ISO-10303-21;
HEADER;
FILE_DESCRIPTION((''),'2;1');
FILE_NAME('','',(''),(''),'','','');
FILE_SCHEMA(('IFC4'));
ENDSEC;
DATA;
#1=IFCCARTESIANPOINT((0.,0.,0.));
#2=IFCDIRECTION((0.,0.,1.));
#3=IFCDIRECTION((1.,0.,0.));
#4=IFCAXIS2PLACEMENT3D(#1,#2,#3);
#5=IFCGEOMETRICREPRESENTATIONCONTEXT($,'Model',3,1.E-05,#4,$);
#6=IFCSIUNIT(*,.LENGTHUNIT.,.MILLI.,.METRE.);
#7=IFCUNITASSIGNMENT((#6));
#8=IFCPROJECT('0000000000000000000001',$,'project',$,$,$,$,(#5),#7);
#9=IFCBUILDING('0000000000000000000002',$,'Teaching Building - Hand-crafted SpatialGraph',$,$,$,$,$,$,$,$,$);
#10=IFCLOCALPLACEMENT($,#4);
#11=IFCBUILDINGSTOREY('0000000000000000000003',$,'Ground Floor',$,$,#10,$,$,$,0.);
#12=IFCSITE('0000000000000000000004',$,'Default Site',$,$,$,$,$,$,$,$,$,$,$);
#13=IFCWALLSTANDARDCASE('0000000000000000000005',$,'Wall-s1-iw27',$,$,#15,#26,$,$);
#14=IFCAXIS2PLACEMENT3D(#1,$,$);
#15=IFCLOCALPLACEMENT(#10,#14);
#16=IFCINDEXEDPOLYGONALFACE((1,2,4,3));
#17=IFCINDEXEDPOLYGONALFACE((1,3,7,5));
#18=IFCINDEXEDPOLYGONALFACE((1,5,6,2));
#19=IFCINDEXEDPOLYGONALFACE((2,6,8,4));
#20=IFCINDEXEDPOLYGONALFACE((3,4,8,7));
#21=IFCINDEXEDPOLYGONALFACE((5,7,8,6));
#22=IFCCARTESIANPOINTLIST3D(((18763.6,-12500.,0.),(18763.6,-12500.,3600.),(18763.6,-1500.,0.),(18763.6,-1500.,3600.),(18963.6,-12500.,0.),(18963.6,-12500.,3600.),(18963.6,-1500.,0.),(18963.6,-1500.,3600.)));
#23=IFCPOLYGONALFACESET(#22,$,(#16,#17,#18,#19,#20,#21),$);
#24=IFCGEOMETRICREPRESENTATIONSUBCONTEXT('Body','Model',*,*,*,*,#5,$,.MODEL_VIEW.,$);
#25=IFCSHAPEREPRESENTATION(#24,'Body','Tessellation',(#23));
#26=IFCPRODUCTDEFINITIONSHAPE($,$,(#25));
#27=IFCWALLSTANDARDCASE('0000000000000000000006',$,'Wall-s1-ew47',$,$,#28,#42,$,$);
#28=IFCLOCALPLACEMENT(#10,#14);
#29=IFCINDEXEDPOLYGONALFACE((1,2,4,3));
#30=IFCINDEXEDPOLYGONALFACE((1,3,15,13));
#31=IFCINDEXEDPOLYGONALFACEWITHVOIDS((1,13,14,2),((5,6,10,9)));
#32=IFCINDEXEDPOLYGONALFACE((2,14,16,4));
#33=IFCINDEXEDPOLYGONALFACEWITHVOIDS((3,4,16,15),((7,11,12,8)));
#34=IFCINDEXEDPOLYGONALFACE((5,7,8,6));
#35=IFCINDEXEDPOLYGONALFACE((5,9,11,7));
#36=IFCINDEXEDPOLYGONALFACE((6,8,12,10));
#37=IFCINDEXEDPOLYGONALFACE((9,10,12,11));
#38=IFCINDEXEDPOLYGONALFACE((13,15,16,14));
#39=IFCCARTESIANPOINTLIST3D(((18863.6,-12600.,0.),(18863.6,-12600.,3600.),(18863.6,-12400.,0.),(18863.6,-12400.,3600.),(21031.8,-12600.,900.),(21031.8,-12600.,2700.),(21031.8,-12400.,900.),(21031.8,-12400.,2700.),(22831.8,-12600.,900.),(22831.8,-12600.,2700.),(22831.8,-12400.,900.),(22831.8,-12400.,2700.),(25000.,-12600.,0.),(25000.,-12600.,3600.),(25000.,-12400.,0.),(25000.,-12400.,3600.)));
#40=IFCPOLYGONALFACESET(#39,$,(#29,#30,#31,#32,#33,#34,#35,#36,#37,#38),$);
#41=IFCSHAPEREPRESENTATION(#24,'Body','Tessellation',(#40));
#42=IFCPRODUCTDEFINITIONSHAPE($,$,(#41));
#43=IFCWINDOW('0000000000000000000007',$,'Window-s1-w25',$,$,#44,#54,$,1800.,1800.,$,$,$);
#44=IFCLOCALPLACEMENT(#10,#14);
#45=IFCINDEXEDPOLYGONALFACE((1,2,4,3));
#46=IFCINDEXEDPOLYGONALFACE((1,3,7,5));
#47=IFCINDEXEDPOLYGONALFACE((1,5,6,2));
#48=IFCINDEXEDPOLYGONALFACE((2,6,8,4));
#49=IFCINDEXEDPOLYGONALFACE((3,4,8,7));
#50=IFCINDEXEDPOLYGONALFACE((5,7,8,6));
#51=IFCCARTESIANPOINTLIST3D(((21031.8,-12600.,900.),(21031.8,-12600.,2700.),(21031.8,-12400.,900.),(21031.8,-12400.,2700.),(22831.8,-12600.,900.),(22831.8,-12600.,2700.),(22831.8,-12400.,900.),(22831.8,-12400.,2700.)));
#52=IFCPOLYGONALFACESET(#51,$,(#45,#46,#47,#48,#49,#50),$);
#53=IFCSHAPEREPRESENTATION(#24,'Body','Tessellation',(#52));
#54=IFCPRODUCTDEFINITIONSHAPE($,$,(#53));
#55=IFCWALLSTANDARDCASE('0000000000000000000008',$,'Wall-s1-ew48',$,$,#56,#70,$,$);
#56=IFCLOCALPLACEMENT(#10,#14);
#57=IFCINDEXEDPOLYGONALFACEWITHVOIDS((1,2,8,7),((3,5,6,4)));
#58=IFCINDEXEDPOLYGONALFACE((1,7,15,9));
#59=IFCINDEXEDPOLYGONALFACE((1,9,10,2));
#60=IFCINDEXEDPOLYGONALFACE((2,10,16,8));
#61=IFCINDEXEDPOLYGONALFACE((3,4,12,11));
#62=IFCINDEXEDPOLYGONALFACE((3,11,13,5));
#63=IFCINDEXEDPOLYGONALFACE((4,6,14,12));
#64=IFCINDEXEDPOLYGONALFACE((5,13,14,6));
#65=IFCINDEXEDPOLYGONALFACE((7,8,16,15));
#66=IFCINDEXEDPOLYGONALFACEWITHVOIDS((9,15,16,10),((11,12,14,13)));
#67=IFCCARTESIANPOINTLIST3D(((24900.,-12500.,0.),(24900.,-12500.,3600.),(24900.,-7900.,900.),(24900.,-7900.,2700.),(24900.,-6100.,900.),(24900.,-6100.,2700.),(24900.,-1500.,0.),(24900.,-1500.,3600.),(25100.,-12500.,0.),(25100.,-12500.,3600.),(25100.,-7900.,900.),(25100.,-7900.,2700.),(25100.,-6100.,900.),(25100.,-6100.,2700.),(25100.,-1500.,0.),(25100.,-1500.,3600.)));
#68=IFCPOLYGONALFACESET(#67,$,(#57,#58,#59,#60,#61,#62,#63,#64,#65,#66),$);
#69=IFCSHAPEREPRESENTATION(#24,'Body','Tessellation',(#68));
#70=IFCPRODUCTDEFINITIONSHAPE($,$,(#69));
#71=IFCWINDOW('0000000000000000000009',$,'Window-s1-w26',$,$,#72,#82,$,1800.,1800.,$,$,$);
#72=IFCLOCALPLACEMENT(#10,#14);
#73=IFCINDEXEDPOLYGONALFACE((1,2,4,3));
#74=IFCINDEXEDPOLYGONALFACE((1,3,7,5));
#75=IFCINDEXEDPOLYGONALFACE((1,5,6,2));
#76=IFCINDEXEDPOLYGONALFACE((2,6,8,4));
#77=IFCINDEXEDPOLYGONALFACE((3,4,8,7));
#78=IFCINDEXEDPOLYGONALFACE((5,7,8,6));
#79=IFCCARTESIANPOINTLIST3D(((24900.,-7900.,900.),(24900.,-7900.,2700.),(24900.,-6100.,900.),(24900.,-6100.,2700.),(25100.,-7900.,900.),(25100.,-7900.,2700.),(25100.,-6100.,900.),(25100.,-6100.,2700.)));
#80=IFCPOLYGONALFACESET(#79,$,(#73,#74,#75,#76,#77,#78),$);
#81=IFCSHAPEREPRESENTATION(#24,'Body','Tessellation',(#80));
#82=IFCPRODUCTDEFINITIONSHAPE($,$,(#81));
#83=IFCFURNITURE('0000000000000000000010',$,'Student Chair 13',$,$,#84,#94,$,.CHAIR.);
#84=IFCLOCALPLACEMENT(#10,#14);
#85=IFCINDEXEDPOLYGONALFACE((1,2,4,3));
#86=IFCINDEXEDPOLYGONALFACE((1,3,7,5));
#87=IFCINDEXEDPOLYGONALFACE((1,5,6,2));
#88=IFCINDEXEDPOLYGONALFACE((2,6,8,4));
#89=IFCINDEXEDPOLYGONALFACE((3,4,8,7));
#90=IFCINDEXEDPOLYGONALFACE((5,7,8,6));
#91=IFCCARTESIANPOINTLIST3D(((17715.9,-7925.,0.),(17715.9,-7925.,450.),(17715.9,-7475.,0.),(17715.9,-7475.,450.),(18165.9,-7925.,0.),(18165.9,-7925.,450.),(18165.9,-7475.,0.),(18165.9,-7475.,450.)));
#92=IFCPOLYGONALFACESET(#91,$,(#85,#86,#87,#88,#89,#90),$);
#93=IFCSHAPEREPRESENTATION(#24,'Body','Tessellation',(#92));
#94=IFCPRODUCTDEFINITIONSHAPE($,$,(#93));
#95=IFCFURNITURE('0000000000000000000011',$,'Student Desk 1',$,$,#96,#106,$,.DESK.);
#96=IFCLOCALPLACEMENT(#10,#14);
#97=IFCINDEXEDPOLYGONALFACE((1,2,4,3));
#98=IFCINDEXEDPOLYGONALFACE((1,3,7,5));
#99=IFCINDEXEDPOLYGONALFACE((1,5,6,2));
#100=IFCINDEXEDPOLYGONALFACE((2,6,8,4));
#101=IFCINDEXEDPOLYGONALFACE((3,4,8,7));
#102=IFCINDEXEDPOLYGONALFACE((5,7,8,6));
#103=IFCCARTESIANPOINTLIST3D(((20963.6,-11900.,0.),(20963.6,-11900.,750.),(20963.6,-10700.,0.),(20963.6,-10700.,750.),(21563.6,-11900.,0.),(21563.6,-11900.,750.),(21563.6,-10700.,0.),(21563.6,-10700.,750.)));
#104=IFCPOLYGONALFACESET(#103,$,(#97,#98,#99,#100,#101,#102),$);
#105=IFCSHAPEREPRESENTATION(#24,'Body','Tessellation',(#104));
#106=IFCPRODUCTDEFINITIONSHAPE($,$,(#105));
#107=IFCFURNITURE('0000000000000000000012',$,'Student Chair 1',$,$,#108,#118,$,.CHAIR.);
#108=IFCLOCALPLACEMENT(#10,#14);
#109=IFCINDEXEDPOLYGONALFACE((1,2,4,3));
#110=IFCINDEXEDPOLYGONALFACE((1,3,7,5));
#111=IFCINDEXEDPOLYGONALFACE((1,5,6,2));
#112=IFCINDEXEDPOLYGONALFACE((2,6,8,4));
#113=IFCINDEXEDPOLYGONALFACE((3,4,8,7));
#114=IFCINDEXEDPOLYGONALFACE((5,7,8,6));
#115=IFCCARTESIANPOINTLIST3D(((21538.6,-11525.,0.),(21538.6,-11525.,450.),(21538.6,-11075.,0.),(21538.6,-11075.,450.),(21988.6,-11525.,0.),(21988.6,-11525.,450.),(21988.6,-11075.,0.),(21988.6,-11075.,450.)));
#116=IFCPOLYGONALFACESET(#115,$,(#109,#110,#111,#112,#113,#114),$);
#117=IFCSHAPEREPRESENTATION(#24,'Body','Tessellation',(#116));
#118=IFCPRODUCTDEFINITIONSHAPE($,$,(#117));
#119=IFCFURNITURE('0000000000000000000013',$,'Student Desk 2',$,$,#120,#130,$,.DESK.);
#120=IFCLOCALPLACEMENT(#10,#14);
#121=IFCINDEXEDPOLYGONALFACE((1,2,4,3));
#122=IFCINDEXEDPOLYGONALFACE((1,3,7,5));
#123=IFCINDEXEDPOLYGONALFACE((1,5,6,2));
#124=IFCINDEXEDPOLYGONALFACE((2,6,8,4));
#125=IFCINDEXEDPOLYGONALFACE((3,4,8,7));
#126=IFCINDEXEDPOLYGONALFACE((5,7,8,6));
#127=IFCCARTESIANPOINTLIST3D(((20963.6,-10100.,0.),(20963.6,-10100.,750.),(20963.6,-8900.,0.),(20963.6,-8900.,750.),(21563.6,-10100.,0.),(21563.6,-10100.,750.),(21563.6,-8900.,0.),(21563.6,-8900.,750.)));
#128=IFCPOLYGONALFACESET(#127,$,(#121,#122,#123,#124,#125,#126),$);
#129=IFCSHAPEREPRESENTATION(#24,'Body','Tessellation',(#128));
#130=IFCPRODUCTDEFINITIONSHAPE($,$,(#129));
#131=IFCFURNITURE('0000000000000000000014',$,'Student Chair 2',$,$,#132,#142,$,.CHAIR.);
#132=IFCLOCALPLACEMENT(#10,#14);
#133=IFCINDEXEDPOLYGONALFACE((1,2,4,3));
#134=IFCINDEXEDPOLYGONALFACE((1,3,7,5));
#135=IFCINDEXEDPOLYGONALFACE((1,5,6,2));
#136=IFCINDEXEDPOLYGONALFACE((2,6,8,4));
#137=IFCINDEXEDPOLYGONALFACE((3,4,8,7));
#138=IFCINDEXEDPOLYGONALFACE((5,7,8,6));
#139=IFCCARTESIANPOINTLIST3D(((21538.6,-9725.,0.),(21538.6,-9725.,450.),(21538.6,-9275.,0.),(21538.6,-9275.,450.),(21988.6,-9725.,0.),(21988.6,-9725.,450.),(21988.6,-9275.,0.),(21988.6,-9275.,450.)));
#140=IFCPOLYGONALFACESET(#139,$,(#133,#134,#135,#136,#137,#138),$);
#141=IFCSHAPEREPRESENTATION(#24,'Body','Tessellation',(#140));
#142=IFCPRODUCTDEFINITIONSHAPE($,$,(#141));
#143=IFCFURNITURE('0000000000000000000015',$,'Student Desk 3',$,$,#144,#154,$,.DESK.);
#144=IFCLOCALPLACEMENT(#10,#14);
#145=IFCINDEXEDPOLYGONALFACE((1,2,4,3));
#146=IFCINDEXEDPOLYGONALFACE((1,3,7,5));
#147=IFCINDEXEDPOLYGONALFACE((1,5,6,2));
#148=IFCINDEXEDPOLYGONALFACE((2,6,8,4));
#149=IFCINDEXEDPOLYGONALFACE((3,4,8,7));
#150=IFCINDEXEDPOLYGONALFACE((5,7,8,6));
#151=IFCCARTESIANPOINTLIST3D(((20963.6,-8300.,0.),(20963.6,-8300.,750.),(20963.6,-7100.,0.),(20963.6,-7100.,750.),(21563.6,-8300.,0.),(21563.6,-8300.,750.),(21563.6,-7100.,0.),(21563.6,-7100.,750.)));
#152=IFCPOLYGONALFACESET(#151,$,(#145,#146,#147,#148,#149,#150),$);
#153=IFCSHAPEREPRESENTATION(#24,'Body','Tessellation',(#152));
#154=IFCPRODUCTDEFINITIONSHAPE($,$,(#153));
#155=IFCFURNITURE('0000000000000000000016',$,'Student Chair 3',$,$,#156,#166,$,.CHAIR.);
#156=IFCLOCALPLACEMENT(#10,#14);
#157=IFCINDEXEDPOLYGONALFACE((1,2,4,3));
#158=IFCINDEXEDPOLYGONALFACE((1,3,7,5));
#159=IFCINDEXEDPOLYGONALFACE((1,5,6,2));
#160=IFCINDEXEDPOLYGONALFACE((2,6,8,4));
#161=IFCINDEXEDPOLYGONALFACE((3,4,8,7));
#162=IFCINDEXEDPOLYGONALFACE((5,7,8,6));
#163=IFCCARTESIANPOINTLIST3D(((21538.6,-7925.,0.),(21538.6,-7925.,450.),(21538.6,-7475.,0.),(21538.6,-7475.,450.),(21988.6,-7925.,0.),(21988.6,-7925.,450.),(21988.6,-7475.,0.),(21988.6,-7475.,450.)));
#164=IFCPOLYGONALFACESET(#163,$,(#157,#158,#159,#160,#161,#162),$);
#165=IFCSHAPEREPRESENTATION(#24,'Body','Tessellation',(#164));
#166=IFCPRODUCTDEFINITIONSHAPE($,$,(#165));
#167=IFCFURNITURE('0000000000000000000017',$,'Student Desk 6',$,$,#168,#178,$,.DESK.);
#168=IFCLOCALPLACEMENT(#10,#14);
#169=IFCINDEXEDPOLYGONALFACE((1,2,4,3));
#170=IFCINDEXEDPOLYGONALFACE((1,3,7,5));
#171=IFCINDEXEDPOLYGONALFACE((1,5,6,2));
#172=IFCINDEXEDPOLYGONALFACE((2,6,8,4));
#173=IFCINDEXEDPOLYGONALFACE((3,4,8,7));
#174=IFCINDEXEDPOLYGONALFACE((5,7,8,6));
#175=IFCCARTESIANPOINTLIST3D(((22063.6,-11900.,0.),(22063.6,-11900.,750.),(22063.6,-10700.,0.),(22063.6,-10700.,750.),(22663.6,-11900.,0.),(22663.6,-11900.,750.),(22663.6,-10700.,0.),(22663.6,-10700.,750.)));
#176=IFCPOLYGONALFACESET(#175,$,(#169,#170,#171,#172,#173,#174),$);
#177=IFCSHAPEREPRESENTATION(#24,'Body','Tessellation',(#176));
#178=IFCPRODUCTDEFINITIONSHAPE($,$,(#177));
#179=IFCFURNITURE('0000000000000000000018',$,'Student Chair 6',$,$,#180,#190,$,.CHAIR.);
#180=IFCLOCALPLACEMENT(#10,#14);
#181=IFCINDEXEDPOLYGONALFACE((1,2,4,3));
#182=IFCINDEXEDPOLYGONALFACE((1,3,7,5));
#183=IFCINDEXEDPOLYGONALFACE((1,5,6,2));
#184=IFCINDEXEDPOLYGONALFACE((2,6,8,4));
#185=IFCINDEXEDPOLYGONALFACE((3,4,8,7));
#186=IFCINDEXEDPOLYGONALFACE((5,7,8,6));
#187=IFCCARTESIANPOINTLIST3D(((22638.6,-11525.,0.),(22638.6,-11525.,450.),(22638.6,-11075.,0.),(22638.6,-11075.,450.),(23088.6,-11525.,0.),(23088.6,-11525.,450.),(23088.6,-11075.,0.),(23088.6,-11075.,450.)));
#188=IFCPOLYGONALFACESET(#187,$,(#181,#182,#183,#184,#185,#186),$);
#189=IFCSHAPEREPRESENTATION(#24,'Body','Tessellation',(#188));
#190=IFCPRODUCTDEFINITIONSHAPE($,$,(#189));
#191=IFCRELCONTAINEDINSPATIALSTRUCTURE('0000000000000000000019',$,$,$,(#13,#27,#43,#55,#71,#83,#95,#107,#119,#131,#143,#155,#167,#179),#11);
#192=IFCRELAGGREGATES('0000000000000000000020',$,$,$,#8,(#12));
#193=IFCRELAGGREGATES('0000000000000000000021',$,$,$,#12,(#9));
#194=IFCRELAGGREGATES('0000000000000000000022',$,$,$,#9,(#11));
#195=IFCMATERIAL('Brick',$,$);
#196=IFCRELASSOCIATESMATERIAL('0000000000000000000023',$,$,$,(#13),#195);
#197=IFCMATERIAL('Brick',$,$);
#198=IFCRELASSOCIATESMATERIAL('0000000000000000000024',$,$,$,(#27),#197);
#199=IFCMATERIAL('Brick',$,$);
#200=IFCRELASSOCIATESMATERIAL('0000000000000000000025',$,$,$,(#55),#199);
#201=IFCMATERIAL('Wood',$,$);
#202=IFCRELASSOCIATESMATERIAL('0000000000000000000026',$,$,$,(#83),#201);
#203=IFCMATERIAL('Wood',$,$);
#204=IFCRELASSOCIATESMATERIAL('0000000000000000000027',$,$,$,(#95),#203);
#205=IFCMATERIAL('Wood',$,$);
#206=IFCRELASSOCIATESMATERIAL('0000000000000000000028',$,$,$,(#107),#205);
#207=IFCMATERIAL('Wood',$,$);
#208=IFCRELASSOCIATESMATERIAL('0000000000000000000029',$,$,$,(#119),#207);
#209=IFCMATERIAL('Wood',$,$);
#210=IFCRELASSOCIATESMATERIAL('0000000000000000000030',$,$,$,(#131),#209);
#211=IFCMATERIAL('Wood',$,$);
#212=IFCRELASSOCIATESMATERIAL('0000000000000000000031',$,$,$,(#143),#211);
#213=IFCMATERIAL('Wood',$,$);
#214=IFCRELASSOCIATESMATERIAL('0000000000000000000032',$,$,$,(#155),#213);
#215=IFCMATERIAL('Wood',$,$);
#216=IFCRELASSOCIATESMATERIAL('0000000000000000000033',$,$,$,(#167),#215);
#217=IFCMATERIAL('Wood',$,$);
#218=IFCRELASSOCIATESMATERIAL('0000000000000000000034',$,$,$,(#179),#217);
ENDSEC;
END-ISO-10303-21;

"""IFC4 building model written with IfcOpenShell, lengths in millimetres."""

from ifc_helpers import new_model, si_unit, frame, frame_2d, origin_with_axes, origin_2d, place, context, subcontext, project, spatial, rectangle, extrude, material, element, fill, save


model = new_model("IFC4")

# Units and contexts
model_context = context("Model", 3, precision=1e-05, world=origin_with_axes())
body_context = subcontext(model_context, "Body", "Model", "MODEL_VIEW")
ifc_project = project(units=[si_unit("LENGTHUNIT", "METRE", prefix="MILLI")], contexts=[model_context])

# Site, building, storey
site = spatial("IfcSite", under=ifc_project, Name="Default Site")
building = spatial("IfcBuilding", under=site, Name="Teaching Building - Hand-crafted SpatialGraph")
storey_placement = place(None, origin_with_axes())
storey = spatial("IfcBuildingStorey", under=building, at=storey_placement, Name="Ground Floor", Elevation=0.0)

# Wall
ifc_material_1 = material(Name="Brick")
wall_1_placement = place(storey_placement, frame((18863.6, -12500.0, 0.0), z_axis=(0.0, 0.0, 1.0), x_axis=(0.0, 1.0, 0.0)))
element("IfcWallStandardCase", 1, at=wall_1_placement, inside=storey, material=ifc_material_1, Name="Wall-s1-iw27", context=body_context, shape_type="SweptSolid", body=[
    extrude(rectangle(XDim=11000.0, YDim=200.0, at=frame_2d((5500.0, 0.0))), origin_with_axes(), (0.0, 0.0, 1.0), 3600.0),
])

# Walls, openings, windows
ifc_material_2 = material(Name="Brick")
wall_2_placement = place(storey_placement, frame((18863.6, -12500.0, 0.0), z_axis=(0.0, 0.0, 1.0), x_axis=(1.0, 0.0, 0.0)))
wall_2 = element("IfcWallStandardCase", 2, at=wall_2_placement, inside=storey, material=ifc_material_2, Name="Wall-s1-ew47", context=body_context, shape_type="SweptSolid", body=[
    extrude(rectangle(XDim=6136.4, YDim=200.0, at=frame_2d((3068.2, 0.0))), origin_with_axes(), (0.0, 0.0, 1.0), 3600.0),
])
opening_1_placement = place(wall_2_placement, frame((2168.2, 0.0, 900.0), z_axis=(0.0, 0.0, 1.0), x_axis=(1.0, 0.0, 0.0)))
opening_1 = element("IfcOpeningElement", 3, at=opening_1_placement, cuts=wall_2, context=body_context, shape_type="SweptSolid", body=[
    extrude(rectangle(XDim=1800.0, YDim=400.0, at=frame_2d((900.0, 0.0))), origin_with_axes(), (0.0, 0.0, 1.0), 1800.0),
])
window_1_placement = place(storey_placement, frame((21031.8, -12500.0, 900.0), z_axis=(0.0, 0.0, 1.0), x_axis=(1.0, 0.0, 0.0)))
window_1 = element("IfcWindow", 4, at=window_1_placement, inside=storey, Name="Window-s1-w25", OverallHeight=1800.0, OverallWidth=1800.0, context=body_context, shape_type="SweptSolid", body=[
    extrude(rectangle(XDim=1800.0, YDim=200.0, at=frame_2d((900.0, 0.0))), origin_with_axes(), (0.0, 0.0, 1.0), 1800.0),
])
fill(opening_1, window_1)
ifc_material_3 = material(Name="Brick")
wall_3_placement = place(storey_placement, frame((25000.0, -12500.0, 0.0), z_axis=(0.0, 0.0, 1.0), x_axis=(0.0, 1.0, 0.0)))
wall_3 = element("IfcWallStandardCase", 5, at=wall_3_placement, inside=storey, material=ifc_material_3, Name="Wall-s1-ew48", context=body_context, shape_type="SweptSolid", body=[
    extrude(rectangle(XDim=11000.0, YDim=200.0, at=frame_2d((5500.0, 0.0))), origin_with_axes(), (0.0, 0.0, 1.0), 3600.0),
])
opening_2_placement = place(wall_3_placement, frame((4600.0, 0.0, 900.0), z_axis=(0.0, 0.0, 1.0), x_axis=(1.0, 0.0, 0.0)))
opening_2 = element("IfcOpeningElement", 6, at=opening_2_placement, cuts=wall_3, context=body_context, shape_type="SweptSolid", body=[
    extrude(rectangle(XDim=1800.0, YDim=400.0, at=frame_2d((900.0, 0.0))), origin_with_axes(), (0.0, 0.0, 1.0), 1800.0),
])
window_2_placement = place(storey_placement, frame((25000.0, -7900.0, 900.0), z_axis=(0.0, 0.0, 1.0), x_axis=(0.0, 1.0, 0.0)))
window_2 = element("IfcWindow", 7, at=window_2_placement, inside=storey, Name="Window-s1-w26", OverallHeight=1800.0, OverallWidth=1800.0, context=body_context, shape_type="SweptSolid", body=[
    extrude(rectangle(XDim=1800.0, YDim=200.0, at=frame_2d((900.0, 0.0))), origin_with_axes(), (0.0, 0.0, 1.0), 1800.0),
])
fill(opening_2, window_2)

# Furniture
ifc_material_4 = material(Name="Wood")
furniture_1_placement = place(storey_placement, frame((17940.9, -7700.0, 0.0), z_axis=(0.0, 0.0, 1.0), x_axis=(1.0, 0.0, 0.0)))
element("IfcFurniture", 8, at=furniture_1_placement, inside=storey, material=ifc_material_4, Name="Student Chair 13", PredefinedType="CHAIR", context=body_context, shape_type="SweptSolid", body=[
    extrude(rectangle(XDim=450.0, YDim=450.0, at=origin_2d()), origin_with_axes(), (0.0, 0.0, 1.0), 450.0),
])
ifc_material_5 = material(Name="Wood")
furniture_2_placement = place(storey_placement, frame((21263.6, -11300.0, 0.0), z_axis=(0.0, 0.0, 1.0), x_axis=(0.0, 1.0, 0.0)))
element("IfcFurniture", 9, at=furniture_2_placement, inside=storey, material=ifc_material_5, Name="Student Desk 1", PredefinedType="DESK", context=body_context, shape_type="SweptSolid", body=[
    extrude(rectangle(XDim=1200.0, YDim=600.0, at=origin_2d()), origin_with_axes(), (0.0, 0.0, 1.0), 750.0),
])
ifc_material_6 = material(Name="Wood")
furniture_3_placement = place(storey_placement, frame((21763.6, -11300.0, 0.0), z_axis=(0.0, 0.0, 1.0), x_axis=(1.0, 0.0, 0.0)))
element("IfcFurniture", 10, at=furniture_3_placement, inside=storey, material=ifc_material_6, Name="Student Chair 1", PredefinedType="CHAIR", context=body_context, shape_type="SweptSolid", body=[
    extrude(rectangle(XDim=450.0, YDim=450.0, at=origin_2d()), origin_with_axes(), (0.0, 0.0, 1.0), 450.0),
])
ifc_material_7 = material(Name="Wood")
furniture_4_placement = place(storey_placement, frame((21263.6, -9500.0, 0.0), z_axis=(0.0, 0.0, 1.0), x_axis=(0.0, 1.0, 0.0)))
element("IfcFurniture", 11, at=furniture_4_placement, inside=storey, material=ifc_material_7, Name="Student Desk 2", PredefinedType="DESK", context=body_context, shape_type="SweptSolid", body=[
    extrude(rectangle(XDim=1200.0, YDim=600.0, at=origin_2d()), origin_with_axes(), (0.0, 0.0, 1.0), 750.0),
])
ifc_material_8 = material(Name="Wood")
furniture_5_placement = place(storey_placement, frame((21763.6, -9500.0, 0.0), z_axis=(0.0, 0.0, 1.0), x_axis=(1.0, 0.0, 0.0)))
element("IfcFurniture", 12, at=furniture_5_placement, inside=storey, material=ifc_material_8, Name="Student Chair 2", PredefinedType="CHAIR", context=body_context, shape_type="SweptSolid", body=[
    extrude(rectangle(XDim=450.0, YDim=450.0, at=origin_2d()), origin_with_axes(), (0.0, 0.0, 1.0), 450.0),
])
ifc_material_9 = material(Name="Wood")
furniture_6_placement = place(storey_placement, frame((21263.6, -7700.0, 0.0), z_axis=(0.0, 0.0, 1.0), x_axis=(0.0, 1.0, 0.0)))
element("IfcFurniture", 13, at=furniture_6_placement, inside=storey, material=ifc_material_9, Name="Student Desk 3", PredefinedType="DESK", context=body_context, shape_type="SweptSolid", body=[
    extrude(rectangle(XDim=1200.0, YDim=600.0, at=origin_2d()), origin_with_axes(), (0.0, 0.0, 1.0), 750.0),
])
ifc_material_10 = material(Name="Wood")
furniture_7_placement = place(storey_placement, frame((21763.6, -7700.0, 0.0), z_axis=(0.0, 0.0, 1.0), x_axis=(1.0, 0.0, 0.0)))
element("IfcFurniture", 14, at=furniture_7_placement, inside=storey, material=ifc_material_10, Name="Student Chair 3", PredefinedType="CHAIR", context=body_context, shape_type="SweptSolid", body=[
    extrude(rectangle(XDim=450.0, YDim=450.0, at=origin_2d()), origin_with_axes(), (0.0, 0.0, 1.0), 450.0),
])
ifc_material_11 = material(Name="Wood")
furniture_8_placement = place(storey_placement, frame((22363.6, -11300.0, 0.0), z_axis=(0.0, 0.0, 1.0), x_axis=(0.0, 1.0, 0.0)))
element("IfcFurniture", 15, at=furniture_8_placement, inside=storey, material=ifc_material_11, Name="Student Desk 6", PredefinedType="DESK", context=body_context, shape_type="SweptSolid", body=[
    extrude(rectangle(XDim=1200.0, YDim=600.0, at=origin_2d()), origin_with_axes(), (0.0, 0.0, 1.0), 750.0),
])
ifc_material_12 = material(Name="Wood")
furniture_9_placement = place(storey_placement, frame((22863.6, -11300.0, 0.0), z_axis=(0.0, 0.0, 1.0), x_axis=(1.0, 0.0, 0.0)))
element("IfcFurniture", 16, at=furniture_9_placement, inside=storey, material=ifc_material_12, Name="Student Chair 6", PredefinedType="CHAIR", context=body_context, shape_type="SweptSolid", body=[
    extrude(rectangle(XDim=450.0, YDim=450.0, at=origin_2d()), origin_with_axes(), (0.0, 0.0, 1.0), 450.0),
])

save(model, "model.ifc")
